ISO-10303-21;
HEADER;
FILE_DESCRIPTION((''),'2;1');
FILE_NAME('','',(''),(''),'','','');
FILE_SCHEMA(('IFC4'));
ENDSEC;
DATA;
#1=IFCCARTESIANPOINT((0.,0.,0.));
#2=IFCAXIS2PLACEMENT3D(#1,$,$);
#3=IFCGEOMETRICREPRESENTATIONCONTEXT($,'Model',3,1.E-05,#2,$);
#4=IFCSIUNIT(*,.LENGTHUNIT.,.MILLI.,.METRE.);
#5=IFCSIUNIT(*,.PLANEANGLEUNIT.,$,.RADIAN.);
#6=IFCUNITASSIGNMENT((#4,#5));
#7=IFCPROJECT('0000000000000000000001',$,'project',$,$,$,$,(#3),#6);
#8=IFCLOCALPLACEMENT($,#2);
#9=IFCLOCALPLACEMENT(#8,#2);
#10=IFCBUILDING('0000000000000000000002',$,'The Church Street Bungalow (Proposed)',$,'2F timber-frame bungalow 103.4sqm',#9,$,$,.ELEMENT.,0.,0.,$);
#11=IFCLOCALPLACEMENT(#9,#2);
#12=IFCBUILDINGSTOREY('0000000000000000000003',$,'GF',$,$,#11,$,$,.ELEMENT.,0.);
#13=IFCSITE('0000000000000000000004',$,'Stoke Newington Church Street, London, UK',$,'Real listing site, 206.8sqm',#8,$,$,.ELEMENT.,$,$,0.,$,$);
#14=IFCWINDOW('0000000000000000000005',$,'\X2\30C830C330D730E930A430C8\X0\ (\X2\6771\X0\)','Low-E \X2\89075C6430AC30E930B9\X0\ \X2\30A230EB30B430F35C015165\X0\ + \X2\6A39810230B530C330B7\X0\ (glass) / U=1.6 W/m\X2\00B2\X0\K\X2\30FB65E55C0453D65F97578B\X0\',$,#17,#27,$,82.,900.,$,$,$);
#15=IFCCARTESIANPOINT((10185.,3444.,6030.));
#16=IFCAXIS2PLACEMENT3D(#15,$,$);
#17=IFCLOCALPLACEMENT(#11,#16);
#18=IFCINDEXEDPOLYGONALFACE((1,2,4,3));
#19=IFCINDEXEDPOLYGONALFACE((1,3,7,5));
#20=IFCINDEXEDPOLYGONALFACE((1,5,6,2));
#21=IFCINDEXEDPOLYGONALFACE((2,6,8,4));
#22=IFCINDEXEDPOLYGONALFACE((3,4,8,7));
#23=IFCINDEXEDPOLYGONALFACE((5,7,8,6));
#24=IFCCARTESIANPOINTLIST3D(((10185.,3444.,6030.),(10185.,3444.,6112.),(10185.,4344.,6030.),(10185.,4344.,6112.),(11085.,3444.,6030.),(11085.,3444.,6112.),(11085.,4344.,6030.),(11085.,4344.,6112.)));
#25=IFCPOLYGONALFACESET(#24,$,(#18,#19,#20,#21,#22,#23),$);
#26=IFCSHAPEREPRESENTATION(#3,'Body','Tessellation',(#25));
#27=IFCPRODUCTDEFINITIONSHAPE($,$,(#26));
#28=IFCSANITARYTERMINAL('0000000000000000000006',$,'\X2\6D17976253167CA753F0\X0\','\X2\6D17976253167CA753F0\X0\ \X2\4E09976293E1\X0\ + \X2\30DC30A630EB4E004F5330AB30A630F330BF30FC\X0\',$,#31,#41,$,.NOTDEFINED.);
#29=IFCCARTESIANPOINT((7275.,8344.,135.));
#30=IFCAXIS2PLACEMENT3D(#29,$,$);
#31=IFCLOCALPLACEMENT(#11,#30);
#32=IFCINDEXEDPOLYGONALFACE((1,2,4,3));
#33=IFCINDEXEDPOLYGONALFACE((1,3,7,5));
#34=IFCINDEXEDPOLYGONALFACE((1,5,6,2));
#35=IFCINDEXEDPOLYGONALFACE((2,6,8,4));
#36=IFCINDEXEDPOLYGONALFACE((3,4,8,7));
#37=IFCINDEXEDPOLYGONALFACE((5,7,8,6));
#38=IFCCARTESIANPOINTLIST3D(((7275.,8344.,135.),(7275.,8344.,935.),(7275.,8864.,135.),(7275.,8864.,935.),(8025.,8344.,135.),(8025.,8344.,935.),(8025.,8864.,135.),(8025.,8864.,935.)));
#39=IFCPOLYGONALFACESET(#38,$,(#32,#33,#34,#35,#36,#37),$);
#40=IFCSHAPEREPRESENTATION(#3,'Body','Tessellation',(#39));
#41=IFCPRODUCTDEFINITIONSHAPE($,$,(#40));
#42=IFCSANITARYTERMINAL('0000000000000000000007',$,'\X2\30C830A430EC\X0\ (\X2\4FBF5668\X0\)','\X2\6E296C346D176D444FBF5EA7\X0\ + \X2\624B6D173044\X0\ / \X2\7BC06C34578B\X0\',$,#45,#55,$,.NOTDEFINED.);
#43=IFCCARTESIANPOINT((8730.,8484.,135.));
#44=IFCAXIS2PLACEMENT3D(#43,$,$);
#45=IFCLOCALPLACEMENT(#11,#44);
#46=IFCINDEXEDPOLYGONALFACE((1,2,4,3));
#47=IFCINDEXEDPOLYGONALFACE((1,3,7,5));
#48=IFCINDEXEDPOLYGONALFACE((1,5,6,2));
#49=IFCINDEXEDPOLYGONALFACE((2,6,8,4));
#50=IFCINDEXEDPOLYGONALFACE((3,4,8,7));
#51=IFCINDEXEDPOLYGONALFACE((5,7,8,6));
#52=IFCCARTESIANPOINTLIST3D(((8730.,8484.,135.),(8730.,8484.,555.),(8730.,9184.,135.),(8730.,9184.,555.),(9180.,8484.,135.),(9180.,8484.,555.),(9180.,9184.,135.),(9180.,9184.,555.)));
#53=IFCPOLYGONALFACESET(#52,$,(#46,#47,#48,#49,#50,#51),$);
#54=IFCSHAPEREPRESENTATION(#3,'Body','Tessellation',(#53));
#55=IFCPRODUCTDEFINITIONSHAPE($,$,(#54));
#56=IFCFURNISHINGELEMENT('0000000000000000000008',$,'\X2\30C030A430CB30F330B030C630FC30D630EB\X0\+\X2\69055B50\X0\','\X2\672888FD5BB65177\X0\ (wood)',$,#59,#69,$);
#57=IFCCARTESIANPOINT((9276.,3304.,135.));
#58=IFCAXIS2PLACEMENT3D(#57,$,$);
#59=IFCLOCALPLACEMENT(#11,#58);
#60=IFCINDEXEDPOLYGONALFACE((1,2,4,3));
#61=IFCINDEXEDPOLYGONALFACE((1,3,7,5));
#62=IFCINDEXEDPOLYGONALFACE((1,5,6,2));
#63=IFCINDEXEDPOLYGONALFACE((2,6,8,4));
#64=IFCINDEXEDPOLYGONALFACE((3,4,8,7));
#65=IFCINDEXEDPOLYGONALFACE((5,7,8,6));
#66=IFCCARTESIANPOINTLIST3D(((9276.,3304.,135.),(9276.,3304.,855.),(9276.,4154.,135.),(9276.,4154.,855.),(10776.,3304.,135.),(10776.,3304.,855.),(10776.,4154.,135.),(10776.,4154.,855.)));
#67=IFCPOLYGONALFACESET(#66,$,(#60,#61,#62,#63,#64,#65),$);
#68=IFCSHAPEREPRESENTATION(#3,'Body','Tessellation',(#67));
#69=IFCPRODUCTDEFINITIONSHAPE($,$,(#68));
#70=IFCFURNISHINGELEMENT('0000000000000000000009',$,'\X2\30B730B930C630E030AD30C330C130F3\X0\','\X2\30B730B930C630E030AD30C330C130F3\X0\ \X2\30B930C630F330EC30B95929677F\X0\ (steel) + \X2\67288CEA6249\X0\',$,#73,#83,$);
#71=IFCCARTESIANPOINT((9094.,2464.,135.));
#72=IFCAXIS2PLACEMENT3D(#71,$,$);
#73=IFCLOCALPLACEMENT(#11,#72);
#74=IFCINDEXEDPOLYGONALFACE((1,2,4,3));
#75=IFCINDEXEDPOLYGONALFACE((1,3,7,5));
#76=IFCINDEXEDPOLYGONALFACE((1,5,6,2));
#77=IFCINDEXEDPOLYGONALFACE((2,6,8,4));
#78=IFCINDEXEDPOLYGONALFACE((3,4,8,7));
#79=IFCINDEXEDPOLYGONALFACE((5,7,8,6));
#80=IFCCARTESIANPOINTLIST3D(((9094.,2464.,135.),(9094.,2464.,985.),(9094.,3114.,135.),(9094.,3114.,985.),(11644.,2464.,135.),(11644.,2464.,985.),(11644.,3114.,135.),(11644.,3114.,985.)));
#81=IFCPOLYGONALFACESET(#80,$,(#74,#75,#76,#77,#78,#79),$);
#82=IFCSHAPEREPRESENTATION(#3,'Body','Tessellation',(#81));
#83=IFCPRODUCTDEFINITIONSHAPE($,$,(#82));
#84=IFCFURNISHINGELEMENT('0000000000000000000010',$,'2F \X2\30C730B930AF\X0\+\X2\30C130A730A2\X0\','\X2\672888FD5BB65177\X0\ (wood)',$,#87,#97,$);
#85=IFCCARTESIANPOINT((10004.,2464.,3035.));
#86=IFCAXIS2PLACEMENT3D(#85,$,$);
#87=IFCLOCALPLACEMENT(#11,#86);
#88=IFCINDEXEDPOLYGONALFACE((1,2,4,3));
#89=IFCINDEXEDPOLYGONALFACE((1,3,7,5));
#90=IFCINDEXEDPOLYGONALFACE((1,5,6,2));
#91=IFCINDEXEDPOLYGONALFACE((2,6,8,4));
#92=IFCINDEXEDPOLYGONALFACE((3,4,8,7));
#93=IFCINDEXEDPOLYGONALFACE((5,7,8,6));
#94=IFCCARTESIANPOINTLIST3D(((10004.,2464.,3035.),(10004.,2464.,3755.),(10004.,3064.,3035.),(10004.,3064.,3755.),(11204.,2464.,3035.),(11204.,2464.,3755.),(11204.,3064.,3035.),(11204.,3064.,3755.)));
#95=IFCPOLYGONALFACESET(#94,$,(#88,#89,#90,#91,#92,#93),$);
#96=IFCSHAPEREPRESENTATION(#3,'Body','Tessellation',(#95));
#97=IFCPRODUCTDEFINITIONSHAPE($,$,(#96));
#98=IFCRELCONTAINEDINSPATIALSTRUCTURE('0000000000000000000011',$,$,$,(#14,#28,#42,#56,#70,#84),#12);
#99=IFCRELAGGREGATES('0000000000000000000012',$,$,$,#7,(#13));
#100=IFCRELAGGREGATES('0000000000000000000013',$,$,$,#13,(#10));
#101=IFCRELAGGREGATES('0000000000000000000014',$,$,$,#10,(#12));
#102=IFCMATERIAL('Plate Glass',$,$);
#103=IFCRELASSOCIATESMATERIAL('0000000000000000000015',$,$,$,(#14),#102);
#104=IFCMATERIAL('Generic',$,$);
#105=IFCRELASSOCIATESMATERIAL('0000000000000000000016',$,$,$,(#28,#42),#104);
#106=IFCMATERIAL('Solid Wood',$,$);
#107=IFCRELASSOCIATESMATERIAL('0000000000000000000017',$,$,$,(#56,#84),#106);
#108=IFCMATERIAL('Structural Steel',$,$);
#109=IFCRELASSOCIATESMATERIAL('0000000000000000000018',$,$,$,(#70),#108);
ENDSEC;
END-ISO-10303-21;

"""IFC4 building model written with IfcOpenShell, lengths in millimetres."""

from ifc_helpers import new_model, si_unit, frame, frame_2d, origin, place, context, project, spatial, rectangle, extrude, material, element, save


model = new_model("IFC4")

# Units and contexts
model_context = context("Model", 3, precision=1e-05, world=origin())
ifc_project = project(units=[si_unit("LENGTHUNIT", "METRE", prefix="MILLI"), si_unit("PLANEANGLEUNIT", "RADIAN")], contexts=[model_context])

# Site, building, storey
site_placement = place(None, origin())
site = spatial("IfcSite", under=ifc_project, at=site_placement, Name="Stoke Newington Church Street, London, UK", ObjectType="Real listing site, 206.8sqm", CompositionType="ELEMENT", RefElevation=0.0)
building_placement = place(site_placement, origin())
building = spatial("IfcBuilding", under=site, at=building_placement, Name="The Church Street Bungalow (Proposed)", ObjectType="2F timber-frame bungalow 103.4sqm", CompositionType="ELEMENT", ElevationOfRefHeight=0.0, ElevationOfTerrain=0.0)
storey_placement = place(building_placement, origin())
storey = spatial("IfcBuildingStorey", under=building, at=storey_placement, Name="GF", CompositionType="ELEMENT", Elevation=0.0)

# Shared definitions
ifc_material_1 = material(Name="Solid Wood")

# Shared definitions
ifc_material_2 = material(Name="Plate Glass")

# Window
window_1_placement = place(storey_placement, frame((10185.0, 3444.0, 6030.0)))
element("IfcWindow", 1, at=window_1_placement, inside=storey, material=ifc_material_2, Name="トップライト (東)", Description="Low-E 複層ガラス アルゴン封入 + 樹脂サッシ (glass) / U=1.6 W/m²K・日射取得型", OverallHeight=82.0, OverallWidth=900.0, context=model_context, shape_type="SweptSolid", body=[
    extrude(rectangle(XDim=900.0, YDim=900.0, at=frame_2d((450.0, 450.0))), frame((10185.0, 3444.0, 6030.0)), (0.0, 0.0, 1.0), 82.0),
])

# Sanitary terminals
ifc_material_3 = material(Name="Generic")
sanitary_terminal_1_placement = place(storey_placement, frame((7275.0, 8344.0, 135.0)))
element("IfcSanitaryTerminal", 2, at=sanitary_terminal_1_placement, inside=storey, material=ifc_material_3, Name="洗面化粧台", Description="洗面化粧台 三面鏡 + ボウル一体カウンター", PredefinedType="NOTDEFINED", context=model_context, shape_type="SweptSolid", body=[
    extrude(rectangle(XDim=750.0, YDim=520.0, at=frame_2d((375.0, 260.0))), frame((7275.0, 8344.0, 135.0)), (0.0, 0.0, 1.0), 800.0),
])
sanitary_terminal_2_placement = place(storey_placement, frame((8730.0, 8484.0, 135.0)))
element("IfcSanitaryTerminal", 3, at=sanitary_terminal_2_placement, inside=storey, material=ifc_material_3, Name="トイレ (便器)", Description="温水洗浄便座 + 手洗い / 節水型", PredefinedType="NOTDEFINED", context=model_context, shape_type="SweptSolid", body=[
    extrude(rectangle(XDim=450.0, YDim=700.0, at=frame_2d((225.0, 350.0))), frame((8730.0, 8484.0, 135.0)), (0.0, 0.0, 1.0), 420.0),
])

# Furnishing elements
furnishing_1_placement = place(storey_placement, frame((9276.0, 3304.0, 135.0)))
element("IfcFurnishingElement", 4, at=furnishing_1_placement, inside=storey, material=ifc_material_1, Name="ダイニングテーブル+椅子", Description="木製家具 (wood)", context=model_context, shape_type="SweptSolid", body=[
    extrude(rectangle(XDim=1500.0, YDim=850.0, at=frame_2d((750.0, 425.0))), frame((9276.0, 3304.0, 135.0)), (0.0, 0.0, 1.0), 720.0),
])
ifc_material_4 = material(Name="Structural Steel")
furnishing_2_placement = place(storey_placement, frame((9094.0, 2464.0, 135.0)))
element("IfcFurnishingElement", 5, at=furnishing_2_placement, inside=storey, material=ifc_material_4, Name="システムキッチン", Description="システムキッチン ステンレス天板 (steel) + 木質扉", context=model_context, shape_type="SweptSolid", body=[
    extrude(rectangle(XDim=2550.0, YDim=650.0, at=frame_2d((1275.0, 325.0))), frame((9094.0, 2464.0, 135.0)), (0.0, 0.0, 1.0), 850.0),
])
furnishing_3_placement = place(storey_placement, frame((10004.0, 2464.0, 3035.0)))
element("IfcFurnishingElement", 6, at=furnishing_3_placement, inside=storey, material=ifc_material_1, Name="2F デスク+チェア", Description="木製家具 (wood)", context=model_context, shape_type="SweptSolid", body=[
    extrude(rectangle(XDim=1200.0, YDim=600.0, at=frame_2d((600.0, 300.0))), frame((10004.0, 2464.0, 3035.0)), (0.0, 0.0, 1.0), 720.0),
])

save(model, "model.ifc")
